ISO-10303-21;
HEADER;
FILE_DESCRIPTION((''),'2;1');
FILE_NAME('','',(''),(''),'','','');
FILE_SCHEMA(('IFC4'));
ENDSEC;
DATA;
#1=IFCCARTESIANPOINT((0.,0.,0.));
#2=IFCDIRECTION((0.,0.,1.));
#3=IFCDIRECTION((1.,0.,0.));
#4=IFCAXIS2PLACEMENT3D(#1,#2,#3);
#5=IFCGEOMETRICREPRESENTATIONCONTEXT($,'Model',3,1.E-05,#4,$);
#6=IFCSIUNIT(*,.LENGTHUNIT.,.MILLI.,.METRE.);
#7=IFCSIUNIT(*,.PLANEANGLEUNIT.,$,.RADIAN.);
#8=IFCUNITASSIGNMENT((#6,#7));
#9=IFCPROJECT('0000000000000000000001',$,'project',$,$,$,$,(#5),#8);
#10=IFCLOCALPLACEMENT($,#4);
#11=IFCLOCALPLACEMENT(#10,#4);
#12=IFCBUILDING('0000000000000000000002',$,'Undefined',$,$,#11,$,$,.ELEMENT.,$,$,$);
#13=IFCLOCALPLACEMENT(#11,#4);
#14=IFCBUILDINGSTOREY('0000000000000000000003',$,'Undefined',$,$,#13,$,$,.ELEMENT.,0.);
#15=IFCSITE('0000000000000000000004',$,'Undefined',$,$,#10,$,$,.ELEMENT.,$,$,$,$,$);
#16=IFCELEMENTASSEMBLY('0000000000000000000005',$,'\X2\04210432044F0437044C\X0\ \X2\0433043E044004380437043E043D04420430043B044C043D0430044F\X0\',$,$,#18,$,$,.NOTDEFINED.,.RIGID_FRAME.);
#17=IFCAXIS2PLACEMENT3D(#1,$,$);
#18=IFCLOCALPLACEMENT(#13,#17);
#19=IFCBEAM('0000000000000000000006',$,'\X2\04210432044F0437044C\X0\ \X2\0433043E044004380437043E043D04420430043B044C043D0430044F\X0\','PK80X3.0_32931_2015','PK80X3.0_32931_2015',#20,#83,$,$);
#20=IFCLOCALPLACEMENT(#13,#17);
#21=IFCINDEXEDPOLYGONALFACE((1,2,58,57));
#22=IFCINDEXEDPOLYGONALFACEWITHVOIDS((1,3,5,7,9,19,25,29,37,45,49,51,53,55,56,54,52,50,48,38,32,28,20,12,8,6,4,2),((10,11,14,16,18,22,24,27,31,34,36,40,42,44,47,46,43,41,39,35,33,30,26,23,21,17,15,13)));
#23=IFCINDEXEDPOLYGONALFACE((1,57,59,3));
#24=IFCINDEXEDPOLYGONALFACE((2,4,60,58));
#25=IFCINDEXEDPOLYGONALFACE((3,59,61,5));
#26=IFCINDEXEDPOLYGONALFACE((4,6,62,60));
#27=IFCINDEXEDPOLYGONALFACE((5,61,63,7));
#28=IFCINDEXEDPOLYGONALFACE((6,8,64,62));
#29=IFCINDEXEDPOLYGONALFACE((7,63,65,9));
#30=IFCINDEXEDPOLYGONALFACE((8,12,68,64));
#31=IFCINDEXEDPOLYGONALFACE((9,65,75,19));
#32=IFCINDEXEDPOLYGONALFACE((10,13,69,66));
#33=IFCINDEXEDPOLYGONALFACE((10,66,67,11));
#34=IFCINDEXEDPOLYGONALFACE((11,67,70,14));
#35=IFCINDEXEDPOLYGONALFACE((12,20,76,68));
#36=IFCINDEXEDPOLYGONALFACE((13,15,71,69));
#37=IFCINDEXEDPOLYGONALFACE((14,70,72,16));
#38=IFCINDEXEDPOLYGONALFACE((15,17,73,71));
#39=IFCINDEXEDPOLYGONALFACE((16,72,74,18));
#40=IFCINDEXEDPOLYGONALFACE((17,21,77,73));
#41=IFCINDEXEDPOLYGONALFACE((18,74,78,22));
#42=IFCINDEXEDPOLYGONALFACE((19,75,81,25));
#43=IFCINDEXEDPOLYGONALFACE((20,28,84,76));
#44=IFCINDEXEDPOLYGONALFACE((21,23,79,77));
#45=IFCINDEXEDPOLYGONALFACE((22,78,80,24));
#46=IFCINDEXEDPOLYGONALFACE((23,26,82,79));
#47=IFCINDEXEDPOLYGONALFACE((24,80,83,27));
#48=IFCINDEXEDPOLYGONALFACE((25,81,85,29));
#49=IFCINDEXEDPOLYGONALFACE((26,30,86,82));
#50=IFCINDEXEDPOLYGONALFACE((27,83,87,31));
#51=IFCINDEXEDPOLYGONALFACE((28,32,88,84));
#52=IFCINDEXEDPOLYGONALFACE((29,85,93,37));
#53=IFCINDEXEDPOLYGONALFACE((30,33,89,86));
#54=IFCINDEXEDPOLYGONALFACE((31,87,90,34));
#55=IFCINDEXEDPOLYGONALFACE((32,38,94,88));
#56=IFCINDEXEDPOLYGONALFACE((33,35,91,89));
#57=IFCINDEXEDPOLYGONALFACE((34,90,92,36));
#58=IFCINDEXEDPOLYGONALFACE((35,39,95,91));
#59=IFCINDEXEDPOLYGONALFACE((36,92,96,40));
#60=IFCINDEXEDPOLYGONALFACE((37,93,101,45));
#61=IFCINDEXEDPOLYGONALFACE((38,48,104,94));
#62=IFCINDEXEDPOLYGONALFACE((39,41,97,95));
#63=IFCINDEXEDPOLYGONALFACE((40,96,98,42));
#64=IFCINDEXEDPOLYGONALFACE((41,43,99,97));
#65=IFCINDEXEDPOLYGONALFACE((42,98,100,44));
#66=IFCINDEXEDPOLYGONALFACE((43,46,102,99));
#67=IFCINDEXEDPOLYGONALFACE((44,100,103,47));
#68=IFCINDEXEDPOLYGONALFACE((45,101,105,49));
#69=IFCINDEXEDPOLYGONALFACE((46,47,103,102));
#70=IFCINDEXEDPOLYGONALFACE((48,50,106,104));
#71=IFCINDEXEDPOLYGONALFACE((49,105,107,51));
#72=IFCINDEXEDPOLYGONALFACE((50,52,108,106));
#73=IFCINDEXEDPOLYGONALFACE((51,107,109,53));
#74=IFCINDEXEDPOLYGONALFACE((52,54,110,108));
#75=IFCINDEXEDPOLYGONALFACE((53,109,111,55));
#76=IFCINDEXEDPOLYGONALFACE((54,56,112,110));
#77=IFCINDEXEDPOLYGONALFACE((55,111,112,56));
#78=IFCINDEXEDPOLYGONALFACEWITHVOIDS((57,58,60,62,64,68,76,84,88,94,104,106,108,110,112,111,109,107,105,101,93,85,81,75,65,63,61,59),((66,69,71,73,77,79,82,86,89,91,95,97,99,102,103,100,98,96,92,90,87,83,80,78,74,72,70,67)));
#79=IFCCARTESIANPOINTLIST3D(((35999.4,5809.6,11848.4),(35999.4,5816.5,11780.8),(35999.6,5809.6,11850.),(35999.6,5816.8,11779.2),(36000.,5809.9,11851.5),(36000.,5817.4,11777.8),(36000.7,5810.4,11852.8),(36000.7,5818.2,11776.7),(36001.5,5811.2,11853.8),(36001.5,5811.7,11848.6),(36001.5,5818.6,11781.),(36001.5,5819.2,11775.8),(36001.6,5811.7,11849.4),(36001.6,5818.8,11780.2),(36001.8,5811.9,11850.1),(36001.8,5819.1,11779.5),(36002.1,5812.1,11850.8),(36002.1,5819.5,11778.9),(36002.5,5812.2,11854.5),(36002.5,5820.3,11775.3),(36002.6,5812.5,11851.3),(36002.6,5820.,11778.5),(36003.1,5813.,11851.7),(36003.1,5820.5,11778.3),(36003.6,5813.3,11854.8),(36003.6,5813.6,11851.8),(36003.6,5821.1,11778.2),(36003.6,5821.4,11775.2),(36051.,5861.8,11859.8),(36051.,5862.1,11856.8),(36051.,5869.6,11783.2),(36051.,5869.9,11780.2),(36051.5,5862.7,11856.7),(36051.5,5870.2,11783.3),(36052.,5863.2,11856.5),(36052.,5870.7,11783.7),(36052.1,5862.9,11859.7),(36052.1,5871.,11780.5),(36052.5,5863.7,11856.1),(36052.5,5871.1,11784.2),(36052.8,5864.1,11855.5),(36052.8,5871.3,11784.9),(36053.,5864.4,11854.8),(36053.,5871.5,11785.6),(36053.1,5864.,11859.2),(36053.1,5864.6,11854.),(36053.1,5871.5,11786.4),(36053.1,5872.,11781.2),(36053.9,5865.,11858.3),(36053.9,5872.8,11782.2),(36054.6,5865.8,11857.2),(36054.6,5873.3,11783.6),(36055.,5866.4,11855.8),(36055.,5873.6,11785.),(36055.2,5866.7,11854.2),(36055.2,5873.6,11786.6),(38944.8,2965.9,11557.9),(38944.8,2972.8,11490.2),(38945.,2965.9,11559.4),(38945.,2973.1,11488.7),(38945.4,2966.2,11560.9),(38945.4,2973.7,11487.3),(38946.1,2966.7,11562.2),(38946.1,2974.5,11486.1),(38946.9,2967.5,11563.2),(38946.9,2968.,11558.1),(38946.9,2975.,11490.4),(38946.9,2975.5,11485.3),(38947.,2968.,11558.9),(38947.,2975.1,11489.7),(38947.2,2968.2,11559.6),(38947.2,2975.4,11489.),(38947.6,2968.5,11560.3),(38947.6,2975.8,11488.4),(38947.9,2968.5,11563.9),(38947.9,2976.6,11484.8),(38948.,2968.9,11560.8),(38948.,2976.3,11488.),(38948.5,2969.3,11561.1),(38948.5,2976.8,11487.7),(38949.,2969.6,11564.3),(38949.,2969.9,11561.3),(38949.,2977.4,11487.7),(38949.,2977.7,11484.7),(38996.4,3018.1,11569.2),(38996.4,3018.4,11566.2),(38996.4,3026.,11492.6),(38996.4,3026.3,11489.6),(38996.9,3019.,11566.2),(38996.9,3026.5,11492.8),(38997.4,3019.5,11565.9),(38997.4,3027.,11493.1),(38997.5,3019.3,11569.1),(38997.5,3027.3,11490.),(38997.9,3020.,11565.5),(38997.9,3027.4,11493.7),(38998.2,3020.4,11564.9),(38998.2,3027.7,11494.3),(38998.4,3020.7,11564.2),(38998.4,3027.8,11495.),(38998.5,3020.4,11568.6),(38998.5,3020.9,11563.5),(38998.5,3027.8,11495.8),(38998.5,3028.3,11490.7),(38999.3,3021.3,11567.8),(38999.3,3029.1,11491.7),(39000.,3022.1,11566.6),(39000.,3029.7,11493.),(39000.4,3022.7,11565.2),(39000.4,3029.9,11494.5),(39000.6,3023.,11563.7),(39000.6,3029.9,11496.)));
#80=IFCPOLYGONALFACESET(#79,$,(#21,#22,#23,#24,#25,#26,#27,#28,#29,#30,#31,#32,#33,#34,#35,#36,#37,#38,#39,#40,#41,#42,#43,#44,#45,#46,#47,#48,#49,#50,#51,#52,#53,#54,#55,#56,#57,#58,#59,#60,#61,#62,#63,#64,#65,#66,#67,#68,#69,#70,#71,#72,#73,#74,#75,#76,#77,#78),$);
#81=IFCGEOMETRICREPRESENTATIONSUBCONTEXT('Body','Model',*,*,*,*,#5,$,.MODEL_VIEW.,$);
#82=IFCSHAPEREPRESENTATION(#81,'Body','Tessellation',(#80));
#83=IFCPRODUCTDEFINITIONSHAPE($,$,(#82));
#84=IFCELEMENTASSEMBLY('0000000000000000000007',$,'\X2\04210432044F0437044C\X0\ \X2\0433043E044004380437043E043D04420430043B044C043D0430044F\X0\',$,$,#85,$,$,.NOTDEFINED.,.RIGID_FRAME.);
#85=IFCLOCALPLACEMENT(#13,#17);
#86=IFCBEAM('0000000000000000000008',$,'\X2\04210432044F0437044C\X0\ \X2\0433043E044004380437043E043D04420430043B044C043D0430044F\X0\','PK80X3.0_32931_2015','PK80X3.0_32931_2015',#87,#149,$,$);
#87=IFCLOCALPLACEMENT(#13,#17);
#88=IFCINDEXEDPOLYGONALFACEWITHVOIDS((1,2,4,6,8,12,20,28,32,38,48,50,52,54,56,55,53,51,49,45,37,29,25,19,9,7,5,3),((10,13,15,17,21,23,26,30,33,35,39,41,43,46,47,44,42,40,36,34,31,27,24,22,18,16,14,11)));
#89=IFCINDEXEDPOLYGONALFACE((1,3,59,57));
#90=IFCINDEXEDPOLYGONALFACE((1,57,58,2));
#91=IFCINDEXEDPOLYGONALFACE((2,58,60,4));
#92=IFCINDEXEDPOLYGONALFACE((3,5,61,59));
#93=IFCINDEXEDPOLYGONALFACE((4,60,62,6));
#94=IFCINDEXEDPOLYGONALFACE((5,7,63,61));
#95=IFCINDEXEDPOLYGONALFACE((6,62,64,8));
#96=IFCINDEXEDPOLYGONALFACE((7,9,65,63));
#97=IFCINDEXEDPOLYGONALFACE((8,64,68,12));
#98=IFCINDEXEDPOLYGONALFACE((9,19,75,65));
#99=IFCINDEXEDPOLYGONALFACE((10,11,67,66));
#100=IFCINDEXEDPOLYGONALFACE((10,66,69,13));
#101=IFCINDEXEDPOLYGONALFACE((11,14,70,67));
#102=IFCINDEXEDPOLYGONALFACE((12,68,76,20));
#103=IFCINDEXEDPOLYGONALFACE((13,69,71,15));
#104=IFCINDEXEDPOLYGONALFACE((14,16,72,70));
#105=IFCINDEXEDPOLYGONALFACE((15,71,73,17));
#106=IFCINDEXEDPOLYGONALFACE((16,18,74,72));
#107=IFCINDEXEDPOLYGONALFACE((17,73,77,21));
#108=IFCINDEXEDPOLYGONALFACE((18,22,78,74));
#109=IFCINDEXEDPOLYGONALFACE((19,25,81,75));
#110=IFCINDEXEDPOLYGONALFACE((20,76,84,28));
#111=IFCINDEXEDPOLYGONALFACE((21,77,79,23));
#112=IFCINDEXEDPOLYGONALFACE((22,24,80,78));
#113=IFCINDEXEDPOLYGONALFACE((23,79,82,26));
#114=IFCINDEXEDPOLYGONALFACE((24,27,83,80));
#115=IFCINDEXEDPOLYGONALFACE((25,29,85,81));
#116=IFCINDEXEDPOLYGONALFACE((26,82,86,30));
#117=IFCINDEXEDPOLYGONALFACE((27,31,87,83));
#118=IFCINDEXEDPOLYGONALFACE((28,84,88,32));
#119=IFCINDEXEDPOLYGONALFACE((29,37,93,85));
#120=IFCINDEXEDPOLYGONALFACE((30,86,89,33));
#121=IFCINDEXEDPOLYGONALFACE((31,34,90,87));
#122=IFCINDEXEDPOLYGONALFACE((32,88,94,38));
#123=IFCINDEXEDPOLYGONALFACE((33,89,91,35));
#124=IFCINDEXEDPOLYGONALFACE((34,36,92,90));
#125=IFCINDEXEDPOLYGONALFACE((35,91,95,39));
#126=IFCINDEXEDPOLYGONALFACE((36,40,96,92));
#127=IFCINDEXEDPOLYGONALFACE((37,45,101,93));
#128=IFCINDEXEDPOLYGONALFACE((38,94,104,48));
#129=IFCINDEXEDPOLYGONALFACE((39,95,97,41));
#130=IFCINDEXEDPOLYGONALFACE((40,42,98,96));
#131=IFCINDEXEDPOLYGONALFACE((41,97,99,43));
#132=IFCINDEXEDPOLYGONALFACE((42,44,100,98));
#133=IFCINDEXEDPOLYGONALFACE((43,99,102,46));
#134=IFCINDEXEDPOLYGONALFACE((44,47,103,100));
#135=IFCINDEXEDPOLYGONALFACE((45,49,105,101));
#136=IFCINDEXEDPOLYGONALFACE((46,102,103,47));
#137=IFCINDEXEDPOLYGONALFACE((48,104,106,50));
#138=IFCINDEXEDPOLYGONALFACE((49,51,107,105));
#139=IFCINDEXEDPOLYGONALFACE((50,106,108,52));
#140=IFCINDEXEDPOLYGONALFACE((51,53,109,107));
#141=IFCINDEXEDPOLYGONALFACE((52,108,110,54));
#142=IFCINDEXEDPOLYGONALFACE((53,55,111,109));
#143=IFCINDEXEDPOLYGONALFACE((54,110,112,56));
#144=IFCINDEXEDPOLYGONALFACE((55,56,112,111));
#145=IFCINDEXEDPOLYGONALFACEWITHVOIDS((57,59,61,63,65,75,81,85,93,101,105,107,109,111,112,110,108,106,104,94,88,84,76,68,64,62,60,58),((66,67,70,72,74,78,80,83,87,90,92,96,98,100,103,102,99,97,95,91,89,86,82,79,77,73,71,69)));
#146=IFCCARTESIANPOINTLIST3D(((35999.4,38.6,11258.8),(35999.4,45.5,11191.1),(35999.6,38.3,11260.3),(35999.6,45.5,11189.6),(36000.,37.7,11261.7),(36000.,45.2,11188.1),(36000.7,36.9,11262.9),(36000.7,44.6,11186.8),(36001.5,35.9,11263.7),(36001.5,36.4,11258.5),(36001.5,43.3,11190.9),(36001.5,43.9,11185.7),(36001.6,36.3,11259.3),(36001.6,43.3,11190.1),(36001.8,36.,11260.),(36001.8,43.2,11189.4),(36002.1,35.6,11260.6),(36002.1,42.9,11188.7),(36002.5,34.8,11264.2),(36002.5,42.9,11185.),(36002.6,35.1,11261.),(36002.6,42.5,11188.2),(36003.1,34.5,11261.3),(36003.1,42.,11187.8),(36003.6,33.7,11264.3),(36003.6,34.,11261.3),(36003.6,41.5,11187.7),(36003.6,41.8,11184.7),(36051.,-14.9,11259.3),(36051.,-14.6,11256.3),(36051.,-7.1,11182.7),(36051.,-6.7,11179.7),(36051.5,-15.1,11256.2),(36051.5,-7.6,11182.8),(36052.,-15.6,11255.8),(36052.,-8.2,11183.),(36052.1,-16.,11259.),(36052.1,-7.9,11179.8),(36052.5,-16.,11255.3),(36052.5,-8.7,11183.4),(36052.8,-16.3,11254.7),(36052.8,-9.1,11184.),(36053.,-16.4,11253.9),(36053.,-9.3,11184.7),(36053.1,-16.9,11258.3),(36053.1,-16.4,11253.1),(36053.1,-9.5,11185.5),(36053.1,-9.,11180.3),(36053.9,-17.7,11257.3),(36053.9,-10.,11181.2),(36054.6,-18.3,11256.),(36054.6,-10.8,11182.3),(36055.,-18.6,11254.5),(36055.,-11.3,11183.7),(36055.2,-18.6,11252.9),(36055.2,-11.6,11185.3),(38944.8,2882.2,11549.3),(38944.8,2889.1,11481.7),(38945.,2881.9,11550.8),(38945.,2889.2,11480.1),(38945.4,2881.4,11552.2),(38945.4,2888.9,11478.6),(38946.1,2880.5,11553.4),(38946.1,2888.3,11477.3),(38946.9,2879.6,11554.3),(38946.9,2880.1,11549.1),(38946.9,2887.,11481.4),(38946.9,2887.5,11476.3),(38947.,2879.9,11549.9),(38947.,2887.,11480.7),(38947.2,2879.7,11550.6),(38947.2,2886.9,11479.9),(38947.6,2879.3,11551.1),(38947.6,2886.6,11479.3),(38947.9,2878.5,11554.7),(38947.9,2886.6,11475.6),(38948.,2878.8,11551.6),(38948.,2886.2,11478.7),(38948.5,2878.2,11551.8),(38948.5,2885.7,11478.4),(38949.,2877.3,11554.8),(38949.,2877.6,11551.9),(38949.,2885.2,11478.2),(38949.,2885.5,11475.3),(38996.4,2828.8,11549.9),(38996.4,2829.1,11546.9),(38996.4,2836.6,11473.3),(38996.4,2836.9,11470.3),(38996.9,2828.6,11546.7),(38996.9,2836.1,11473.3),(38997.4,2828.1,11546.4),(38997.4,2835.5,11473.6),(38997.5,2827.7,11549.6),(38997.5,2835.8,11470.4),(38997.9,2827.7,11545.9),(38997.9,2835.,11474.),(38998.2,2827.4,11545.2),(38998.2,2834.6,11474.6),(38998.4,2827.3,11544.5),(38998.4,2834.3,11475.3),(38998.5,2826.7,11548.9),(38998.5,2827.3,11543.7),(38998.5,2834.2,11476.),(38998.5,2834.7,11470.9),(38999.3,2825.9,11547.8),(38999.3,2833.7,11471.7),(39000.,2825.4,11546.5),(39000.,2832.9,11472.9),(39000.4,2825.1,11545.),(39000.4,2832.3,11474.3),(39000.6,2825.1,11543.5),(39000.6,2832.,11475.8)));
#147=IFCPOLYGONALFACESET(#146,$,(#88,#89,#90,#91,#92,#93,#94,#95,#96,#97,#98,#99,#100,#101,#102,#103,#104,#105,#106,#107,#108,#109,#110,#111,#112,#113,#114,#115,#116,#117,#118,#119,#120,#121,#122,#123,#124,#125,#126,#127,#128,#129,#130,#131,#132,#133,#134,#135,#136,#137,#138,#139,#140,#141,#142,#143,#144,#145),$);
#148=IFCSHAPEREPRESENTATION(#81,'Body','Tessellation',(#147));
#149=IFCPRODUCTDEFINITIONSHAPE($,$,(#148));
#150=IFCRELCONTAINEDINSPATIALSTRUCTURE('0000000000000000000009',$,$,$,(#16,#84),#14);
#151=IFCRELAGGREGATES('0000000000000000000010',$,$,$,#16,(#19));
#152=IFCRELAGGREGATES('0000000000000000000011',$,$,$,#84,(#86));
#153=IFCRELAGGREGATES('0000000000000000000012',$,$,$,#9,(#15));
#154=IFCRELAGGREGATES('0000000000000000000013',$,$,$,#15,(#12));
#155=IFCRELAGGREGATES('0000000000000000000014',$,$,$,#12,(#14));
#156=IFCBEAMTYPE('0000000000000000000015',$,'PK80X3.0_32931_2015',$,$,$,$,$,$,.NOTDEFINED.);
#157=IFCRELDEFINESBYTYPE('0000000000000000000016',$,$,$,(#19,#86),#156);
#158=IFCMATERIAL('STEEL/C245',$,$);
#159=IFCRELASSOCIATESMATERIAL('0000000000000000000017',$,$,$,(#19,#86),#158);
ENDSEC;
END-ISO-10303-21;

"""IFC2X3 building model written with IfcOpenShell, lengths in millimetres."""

from ifc_helpers import new_model, si_unit, frame, origin_with_axes, origin_2d_with_axis, place, context, subcontext, project, spatial, hollow_rectangle, extrude, material, type_object, element, aggregate, save


model = new_model("IFC2X3")

# Units and contexts
model_context = context("Model", 3, precision=1e-05, world=origin_with_axes())
body_context = subcontext(model_context, "Body", "Model", "MODEL_VIEW")
ifc_project = project(units=[si_unit("LENGTHUNIT", "METRE", prefix="MILLI"), si_unit("PLANEANGLEUNIT", "RADIAN")], contexts=[model_context])

# Site, building, storey
site_placement = place(None, origin_with_axes())
site = spatial("IfcSite", under=ifc_project, at=site_placement, Name="Undefined", CompositionType="ELEMENT")
building_placement = place(site_placement, origin_with_axes())
building = spatial("IfcBuilding", under=site, at=building_placement, Name="Undefined", CompositionType="ELEMENT")
storey_placement = place(building_placement, origin_with_axes())
storey = spatial("IfcBuildingStorey", under=building, at=storey_placement, Name="Undefined", CompositionType="ELEMENT", Elevation=0.0)

# Shared definitions
ifc_material_1 = material(Name="STEEL/C245")

# Element assemblies, beams
beam_type_1 = type_object("IfcBeamType", Name="PK80X3.0_32931_2015", PredefinedType="NOTDEFINED")
assembly_1_placement = place(storey_placement, origin_with_axes())
assembly_1 = element("IfcElementAssembly", 1, at=assembly_1_placement, inside=storey, Name="Связь горизонтальная", AssemblyPlace="NOTDEFINED", PredefinedType="RIGID_FRAME")
beam_1_placement = place(assembly_1_placement, frame((36027.3, 5841.6, 11817.5), z_axis=(0.0, -0.101645, 0.994821), x_axis=(0.717617, -0.69283, -0.070789)))
beam_1 = element("IfcBeam", 2, at=beam_1_placement, type_object=beam_type_1, material=ifc_material_1, Name="Связь горизонтальная", Description="PK80X3.0_32931_2015", ObjectType="PK80X3.0_32931_2015", context=body_context, shape_type="SweptSolid", body=[
    extrude(hollow_rectangle(XDim=80.0, YDim=80.0, WallThickness=3.0, InnerFilletRadius=3.0, OuterFilletRadius=6.0, at=origin_2d_with_axis()), frame((4104.4, 0.0, 0.0), z_axis=(-1.0, 0.0, 0.0), x_axis=(0.0, -1.0, 0.0)), (0.0, 0.0, 1.0), 4104.4),
])
aggregate(assembly_1, [beam_1])
assembly_2_placement = place(storey_placement, origin_with_axes())
assembly_2 = element("IfcElementAssembly", 3, at=assembly_2_placement, inside=storey, Name="Связь горизонтальная", AssemblyPlace="NOTDEFINED", PredefinedType="RIGID_FRAME")
beam_2_placement = place(assembly_2_placement, frame((36027.3, 13.5, 11222.0), z_axis=(0.0, -0.101645, 0.994821), x_axis=(0.717617, 0.69283, 0.070789)))
beam_2 = element("IfcBeam", 4, at=beam_2_placement, type_object=beam_type_1, material=ifc_material_1, Name="Связь горизонтальная", Description="PK80X3.0_32931_2015", ObjectType="PK80X3.0_32931_2015", context=body_context, shape_type="SweptSolid", body=[
    extrude(hollow_rectangle(XDim=80.0, YDim=80.0, WallThickness=3.0, InnerFilletRadius=3.0, OuterFilletRadius=6.0, at=origin_2d_with_axis()), frame((4104.4, 0.0, 0.0), z_axis=(-1.0, 0.0, 0.0), x_axis=(0.0, -1.0, 0.0)), (0.0, 0.0, 1.0), 4104.4),
])
aggregate(assembly_2, [beam_2])

save(model, "model.ifc")
